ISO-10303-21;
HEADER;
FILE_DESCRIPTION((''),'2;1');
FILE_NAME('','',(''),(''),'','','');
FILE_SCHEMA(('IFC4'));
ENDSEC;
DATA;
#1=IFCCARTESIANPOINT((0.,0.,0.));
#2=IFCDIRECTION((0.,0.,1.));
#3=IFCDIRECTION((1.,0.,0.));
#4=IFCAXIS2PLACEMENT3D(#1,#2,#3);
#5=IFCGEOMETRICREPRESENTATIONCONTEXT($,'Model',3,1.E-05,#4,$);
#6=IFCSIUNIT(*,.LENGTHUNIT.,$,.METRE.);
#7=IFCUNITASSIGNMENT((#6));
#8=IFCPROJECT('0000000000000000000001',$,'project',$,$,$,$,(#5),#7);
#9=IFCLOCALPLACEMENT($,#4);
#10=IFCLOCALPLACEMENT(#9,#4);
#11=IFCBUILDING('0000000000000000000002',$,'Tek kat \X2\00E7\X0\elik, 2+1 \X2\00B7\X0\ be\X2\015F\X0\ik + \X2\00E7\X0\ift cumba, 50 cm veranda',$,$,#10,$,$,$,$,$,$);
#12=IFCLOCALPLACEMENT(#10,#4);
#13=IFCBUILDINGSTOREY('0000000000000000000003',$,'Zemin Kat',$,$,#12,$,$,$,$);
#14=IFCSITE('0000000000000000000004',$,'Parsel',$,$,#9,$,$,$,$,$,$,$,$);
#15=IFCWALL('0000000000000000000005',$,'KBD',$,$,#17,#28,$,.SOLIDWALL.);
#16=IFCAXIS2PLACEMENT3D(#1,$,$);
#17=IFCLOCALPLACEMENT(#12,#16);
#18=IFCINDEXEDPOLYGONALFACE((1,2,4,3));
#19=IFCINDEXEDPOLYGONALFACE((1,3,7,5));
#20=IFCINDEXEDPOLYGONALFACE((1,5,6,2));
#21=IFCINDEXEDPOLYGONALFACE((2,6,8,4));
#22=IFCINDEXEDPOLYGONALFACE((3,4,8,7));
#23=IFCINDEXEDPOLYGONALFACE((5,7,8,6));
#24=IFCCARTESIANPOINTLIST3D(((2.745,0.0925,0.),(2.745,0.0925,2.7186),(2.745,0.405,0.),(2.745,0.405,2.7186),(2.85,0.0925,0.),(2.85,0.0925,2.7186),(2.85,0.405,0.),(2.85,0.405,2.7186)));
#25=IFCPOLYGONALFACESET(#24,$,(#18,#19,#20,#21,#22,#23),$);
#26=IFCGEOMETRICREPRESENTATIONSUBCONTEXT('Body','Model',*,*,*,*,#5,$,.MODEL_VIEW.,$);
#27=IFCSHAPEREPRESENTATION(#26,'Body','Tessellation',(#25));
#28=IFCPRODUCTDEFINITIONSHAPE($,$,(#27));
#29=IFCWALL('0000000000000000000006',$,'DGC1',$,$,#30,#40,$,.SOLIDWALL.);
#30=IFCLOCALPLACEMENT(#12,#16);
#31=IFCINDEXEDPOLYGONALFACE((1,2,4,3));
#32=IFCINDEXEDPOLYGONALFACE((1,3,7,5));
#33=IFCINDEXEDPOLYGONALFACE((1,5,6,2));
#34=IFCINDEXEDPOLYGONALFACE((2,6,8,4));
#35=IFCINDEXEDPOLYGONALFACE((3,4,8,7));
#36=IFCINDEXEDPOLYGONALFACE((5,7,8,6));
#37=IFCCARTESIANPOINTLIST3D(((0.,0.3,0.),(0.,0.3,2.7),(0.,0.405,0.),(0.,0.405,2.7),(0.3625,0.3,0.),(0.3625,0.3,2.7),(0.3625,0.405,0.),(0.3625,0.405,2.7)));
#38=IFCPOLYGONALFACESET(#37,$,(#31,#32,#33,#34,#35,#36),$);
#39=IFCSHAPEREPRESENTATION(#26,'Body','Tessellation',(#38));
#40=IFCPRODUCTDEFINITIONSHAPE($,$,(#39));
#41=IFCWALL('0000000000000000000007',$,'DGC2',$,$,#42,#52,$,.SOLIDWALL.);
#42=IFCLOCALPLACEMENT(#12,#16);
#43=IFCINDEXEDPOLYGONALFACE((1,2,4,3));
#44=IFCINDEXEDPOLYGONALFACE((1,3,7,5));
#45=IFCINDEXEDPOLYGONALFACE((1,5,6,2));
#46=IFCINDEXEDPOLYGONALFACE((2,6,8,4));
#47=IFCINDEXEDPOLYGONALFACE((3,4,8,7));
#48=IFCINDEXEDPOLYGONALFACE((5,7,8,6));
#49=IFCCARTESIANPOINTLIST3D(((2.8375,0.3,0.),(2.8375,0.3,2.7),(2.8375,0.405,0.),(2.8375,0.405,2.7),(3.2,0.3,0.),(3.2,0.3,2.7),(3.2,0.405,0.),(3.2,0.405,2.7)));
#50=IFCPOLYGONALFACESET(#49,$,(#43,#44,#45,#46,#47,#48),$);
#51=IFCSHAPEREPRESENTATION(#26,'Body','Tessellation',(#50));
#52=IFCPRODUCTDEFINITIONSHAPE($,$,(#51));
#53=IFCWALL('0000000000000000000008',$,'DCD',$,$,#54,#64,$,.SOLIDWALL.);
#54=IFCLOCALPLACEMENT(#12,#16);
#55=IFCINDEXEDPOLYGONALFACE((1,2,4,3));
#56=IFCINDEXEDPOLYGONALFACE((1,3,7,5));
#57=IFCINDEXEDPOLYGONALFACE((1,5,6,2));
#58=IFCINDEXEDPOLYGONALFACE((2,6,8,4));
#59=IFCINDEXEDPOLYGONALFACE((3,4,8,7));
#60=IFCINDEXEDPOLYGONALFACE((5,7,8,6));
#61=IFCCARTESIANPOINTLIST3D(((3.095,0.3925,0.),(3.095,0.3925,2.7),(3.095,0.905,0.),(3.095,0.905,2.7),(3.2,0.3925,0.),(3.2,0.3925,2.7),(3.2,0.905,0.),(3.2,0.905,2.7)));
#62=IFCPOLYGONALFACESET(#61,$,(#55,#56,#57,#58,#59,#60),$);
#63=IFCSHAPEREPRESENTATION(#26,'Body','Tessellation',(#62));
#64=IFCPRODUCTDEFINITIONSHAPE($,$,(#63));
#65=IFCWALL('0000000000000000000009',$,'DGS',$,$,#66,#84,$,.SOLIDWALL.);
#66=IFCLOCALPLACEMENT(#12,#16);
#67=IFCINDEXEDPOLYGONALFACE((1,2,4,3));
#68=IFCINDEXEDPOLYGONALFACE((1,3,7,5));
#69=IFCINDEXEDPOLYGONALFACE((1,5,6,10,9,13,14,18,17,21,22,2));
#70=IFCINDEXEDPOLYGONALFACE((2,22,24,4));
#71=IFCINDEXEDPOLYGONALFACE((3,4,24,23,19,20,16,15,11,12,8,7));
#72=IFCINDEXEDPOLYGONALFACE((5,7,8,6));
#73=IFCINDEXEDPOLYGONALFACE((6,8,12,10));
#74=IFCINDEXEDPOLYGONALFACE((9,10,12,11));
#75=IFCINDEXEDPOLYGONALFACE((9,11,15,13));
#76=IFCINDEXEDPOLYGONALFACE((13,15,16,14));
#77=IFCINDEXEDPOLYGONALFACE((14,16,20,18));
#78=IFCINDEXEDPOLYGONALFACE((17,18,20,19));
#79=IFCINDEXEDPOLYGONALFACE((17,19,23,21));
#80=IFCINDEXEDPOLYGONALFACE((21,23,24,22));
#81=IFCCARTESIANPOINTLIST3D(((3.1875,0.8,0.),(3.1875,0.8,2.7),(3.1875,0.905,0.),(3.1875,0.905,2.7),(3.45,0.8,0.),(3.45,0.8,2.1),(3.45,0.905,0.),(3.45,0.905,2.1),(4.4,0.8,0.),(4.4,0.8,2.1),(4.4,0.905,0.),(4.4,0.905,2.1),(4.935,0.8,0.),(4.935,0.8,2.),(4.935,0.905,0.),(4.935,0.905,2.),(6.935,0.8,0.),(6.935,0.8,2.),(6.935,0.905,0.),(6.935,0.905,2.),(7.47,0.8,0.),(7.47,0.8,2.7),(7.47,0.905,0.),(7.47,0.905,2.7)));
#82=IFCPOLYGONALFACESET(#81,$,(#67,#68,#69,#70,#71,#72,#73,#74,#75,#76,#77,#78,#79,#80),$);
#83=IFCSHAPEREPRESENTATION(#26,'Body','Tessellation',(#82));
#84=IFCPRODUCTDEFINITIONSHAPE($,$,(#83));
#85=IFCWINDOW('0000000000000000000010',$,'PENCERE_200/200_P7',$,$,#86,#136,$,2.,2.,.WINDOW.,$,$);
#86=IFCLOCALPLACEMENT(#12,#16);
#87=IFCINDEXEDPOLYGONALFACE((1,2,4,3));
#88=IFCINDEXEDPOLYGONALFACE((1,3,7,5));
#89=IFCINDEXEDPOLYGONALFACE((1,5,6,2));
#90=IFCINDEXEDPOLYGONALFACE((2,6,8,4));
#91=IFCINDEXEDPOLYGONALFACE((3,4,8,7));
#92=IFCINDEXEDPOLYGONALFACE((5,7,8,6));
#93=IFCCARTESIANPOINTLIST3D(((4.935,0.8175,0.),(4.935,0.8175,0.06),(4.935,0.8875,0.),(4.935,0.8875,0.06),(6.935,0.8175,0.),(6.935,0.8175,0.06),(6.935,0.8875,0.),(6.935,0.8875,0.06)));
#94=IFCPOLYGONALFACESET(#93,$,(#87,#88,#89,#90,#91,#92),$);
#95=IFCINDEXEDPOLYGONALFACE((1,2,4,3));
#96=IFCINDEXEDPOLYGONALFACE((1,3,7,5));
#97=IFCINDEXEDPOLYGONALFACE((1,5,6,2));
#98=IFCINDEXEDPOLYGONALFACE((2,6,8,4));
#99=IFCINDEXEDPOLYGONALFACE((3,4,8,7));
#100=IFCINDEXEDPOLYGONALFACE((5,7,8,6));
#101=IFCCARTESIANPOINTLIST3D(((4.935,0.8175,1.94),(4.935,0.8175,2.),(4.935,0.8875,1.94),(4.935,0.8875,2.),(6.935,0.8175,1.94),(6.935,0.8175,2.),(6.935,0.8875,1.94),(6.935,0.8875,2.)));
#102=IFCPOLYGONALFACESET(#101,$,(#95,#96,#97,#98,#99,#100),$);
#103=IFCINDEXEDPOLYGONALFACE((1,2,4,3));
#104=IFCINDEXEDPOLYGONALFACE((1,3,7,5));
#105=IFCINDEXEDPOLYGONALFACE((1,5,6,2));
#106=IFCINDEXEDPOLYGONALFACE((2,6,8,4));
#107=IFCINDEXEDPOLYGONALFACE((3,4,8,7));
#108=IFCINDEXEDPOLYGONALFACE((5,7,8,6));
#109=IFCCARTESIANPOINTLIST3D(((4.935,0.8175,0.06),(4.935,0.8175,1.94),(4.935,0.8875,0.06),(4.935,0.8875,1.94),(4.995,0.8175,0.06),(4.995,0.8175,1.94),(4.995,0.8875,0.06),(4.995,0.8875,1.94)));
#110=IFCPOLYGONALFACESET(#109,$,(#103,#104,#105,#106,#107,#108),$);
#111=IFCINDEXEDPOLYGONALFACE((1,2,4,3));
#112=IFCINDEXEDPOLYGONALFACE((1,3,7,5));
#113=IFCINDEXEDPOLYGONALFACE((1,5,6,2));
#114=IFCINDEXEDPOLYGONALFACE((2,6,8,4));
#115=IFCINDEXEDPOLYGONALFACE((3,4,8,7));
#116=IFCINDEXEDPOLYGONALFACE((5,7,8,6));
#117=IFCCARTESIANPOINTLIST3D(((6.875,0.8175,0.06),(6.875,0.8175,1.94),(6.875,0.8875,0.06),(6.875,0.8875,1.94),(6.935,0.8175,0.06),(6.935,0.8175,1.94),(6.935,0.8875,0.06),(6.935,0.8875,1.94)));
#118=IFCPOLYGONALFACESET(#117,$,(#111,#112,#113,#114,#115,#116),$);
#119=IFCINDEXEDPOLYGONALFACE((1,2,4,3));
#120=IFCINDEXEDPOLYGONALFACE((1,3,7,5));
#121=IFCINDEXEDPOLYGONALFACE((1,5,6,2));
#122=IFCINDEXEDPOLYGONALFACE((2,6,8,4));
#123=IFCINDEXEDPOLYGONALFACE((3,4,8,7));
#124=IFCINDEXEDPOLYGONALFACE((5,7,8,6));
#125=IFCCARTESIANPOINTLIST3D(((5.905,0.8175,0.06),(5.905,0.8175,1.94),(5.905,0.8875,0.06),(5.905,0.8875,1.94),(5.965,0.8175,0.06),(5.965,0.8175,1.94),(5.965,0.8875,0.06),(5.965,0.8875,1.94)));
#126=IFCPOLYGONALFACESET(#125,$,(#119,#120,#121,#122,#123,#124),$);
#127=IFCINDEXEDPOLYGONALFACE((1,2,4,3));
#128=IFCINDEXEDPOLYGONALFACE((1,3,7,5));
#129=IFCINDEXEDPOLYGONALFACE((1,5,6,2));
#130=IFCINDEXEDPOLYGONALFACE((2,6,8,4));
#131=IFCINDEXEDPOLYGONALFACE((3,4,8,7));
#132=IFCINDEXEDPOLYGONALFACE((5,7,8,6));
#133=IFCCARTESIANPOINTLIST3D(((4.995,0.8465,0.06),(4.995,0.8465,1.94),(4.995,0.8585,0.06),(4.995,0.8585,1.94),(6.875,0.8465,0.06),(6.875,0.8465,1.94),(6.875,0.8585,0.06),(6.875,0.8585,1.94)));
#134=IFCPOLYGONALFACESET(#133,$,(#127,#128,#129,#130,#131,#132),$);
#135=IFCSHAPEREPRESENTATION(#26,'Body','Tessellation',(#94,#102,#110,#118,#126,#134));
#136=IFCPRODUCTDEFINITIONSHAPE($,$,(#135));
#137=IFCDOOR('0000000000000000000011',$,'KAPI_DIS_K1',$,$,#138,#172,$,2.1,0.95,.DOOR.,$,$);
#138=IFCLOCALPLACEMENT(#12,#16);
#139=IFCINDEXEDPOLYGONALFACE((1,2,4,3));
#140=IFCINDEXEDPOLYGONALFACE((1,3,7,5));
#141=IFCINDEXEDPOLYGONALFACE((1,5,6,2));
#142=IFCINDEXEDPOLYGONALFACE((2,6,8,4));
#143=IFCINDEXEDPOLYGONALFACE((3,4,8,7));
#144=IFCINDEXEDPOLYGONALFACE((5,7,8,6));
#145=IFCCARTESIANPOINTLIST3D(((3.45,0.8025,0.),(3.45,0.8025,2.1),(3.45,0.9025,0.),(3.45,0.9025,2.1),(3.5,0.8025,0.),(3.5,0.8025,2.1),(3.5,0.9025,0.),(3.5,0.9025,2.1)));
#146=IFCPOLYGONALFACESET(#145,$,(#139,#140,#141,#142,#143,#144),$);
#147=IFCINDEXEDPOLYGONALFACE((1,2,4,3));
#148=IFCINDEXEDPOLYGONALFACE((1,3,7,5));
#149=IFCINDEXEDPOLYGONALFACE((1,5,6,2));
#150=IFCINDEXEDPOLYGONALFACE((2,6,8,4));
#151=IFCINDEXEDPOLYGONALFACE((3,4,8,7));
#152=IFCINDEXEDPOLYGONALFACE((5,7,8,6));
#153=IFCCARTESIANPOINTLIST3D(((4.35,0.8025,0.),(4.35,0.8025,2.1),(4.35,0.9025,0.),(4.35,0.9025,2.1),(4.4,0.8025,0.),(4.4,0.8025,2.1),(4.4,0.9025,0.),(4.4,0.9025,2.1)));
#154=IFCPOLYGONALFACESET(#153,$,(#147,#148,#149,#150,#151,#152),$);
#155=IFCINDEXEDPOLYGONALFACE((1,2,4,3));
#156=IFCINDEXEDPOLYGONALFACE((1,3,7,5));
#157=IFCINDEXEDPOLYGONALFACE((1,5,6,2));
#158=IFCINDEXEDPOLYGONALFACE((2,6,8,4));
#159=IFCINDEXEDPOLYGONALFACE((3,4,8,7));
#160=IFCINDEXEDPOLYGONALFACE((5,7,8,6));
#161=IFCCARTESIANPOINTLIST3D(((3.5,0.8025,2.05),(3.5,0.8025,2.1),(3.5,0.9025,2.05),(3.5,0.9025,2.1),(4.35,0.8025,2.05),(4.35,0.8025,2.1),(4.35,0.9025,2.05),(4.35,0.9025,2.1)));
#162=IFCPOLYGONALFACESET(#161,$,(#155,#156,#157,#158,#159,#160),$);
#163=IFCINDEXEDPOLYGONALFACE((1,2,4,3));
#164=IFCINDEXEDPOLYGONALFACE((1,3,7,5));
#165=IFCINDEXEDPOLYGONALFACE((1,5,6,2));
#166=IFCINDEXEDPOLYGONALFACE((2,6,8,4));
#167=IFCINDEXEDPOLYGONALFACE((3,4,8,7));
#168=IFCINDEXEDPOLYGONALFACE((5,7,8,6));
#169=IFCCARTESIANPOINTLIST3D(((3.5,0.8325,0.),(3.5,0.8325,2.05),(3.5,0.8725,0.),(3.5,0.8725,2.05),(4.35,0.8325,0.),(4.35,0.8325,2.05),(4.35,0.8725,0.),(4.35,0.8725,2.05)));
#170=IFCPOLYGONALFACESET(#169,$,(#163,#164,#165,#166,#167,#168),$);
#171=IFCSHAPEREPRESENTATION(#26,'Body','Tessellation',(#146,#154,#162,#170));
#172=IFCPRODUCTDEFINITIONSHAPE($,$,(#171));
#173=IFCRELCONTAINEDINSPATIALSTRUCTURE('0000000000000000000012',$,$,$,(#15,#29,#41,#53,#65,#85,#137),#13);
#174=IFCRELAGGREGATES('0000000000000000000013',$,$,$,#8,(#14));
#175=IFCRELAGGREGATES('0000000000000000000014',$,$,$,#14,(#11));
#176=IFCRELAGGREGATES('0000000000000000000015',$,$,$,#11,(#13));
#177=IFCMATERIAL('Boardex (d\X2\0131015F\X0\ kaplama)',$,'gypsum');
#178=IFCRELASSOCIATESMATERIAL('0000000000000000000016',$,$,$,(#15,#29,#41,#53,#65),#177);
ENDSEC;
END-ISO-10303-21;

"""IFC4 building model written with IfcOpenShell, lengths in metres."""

from ifc_helpers import new_model, si_unit, frame, origin_with_axes, place, context, subcontext, project, spatial, line, indexed_curve, outline, extrude, material, element, fill, save


model = new_model("IFC4")

# Units and contexts
model_context = context("Model", 3, precision=1e-05, world=origin_with_axes())
body_context = subcontext(model_context, "Body", "Model", "MODEL_VIEW")
ifc_project = project(units=[si_unit("LENGTHUNIT", "METRE")], contexts=[model_context])

# Site, building, storey
site_placement = place(None, origin_with_axes())
site = spatial("IfcSite", under=ifc_project, at=site_placement, Name="Parsel")
building_placement = place(site_placement, origin_with_axes())
building = spatial("IfcBuilding", under=site, at=building_placement, Name="Tek kat çelik, 2+1 · beşik + çift cumba, 50 cm veranda")
storey_placement = place(building_placement, origin_with_axes())
storey = spatial("IfcBuildingStorey", under=building, at=storey_placement, Name="Zemin Kat")

# Shared definitions
ifc_material_1 = material(Name="Boardex (dış kaplama)", Category="gypsum")

# Walls
wall_1_placement = place(storey_placement, origin_with_axes())
element("IfcWall", 1, at=wall_1_placement, inside=storey, material=ifc_material_1, Name="KBD", PredefinedType="SOLIDWALL", context=body_context, shape_type="SweptSolid", body=[
    extrude(outline(indexed_curve([(0.0, 0.0), (0.105, 0.0), (0.105, 0.3125), (0.0, 0.3125)], segments=[line(1, 2, 3, 4, 1)])), frame((2.745, 0.0925, 0.0), z_axis=(0.0, 0.0, 1.0), x_axis=(1.0, 0.0, 0.0)), (0.0, 0.0, 1.0), 2.7186),
])
wall_2_placement = place(storey_placement, origin_with_axes())
element("IfcWall", 2, at=wall_2_placement, inside=storey, material=ifc_material_1, Name="DGC1", PredefinedType="SOLIDWALL", context=body_context, shape_type="SweptSolid", body=[
    extrude(outline(indexed_curve([(0.0, 0.0), (0.3625, 0.0), (0.3625, 0.105), (0.0, 0.105)], segments=[line(1, 2, 3, 4, 1)])), frame((0.0, 0.3, 0.0), z_axis=(0.0, 0.0, 1.0), x_axis=(1.0, 0.0, 0.0)), (0.0, 0.0, 1.0), 2.7),
])
wall_3_placement = place(storey_placement, origin_with_axes())
element("IfcWall", 3, at=wall_3_placement, inside=storey, material=ifc_material_1, Name="DGC2", PredefinedType="SOLIDWALL", context=body_context, shape_type="SweptSolid", body=[
    extrude(outline(indexed_curve([(0.0, 0.0), (0.3625, 0.0), (0.3625, 0.105), (0.0, 0.105)], segments=[line(1, 2, 3, 4, 1)])), frame((2.8375, 0.3, 0.0), z_axis=(0.0, 0.0, 1.0), x_axis=(1.0, 0.0, 0.0)), (0.0, 0.0, 1.0), 2.7),
])
wall_4_placement = place(storey_placement, origin_with_axes())
element("IfcWall", 4, at=wall_4_placement, inside=storey, material=ifc_material_1, Name="DCD", PredefinedType="SOLIDWALL", context=body_context, shape_type="SweptSolid", body=[
    extrude(outline(indexed_curve([(0.0, 0.0), (0.105, 0.0), (0.105, 0.5125), (0.0, 0.5125)], segments=[line(1, 2, 3, 4, 1)])), frame((3.095, 0.3925, 0.0), z_axis=(0.0, 0.0, 1.0), x_axis=(1.0, 0.0, 0.0)), (0.0, 0.0, 1.0), 2.7),
])

# Wall, openings, window, door
wall_5_placement = place(storey_placement, origin_with_axes())
wall_5 = element("IfcWall", 5, at=wall_5_placement, inside=storey, material=ifc_material_1, Name="DGS", PredefinedType="SOLIDWALL", context=body_context, shape_type="SweptSolid", body=[
    extrude(outline(indexed_curve([(0.0, 0.0), (4.2825, 0.0), (4.2825, 0.105), (0.0, 0.105)], segments=[line(1, 2, 3, 4, 1)])), frame((3.1875, 0.8, 0.0), z_axis=(0.0, 0.0, 1.0), x_axis=(1.0, 0.0, 0.0)), (0.0, 0.0, 1.0), 2.7),
])
opening_1_placement = place(wall_5_placement, origin_with_axes())
opening_1 = element("IfcOpeningElement", 6, at=opening_1_placement, cuts=wall_5, PredefinedType="OPENING", context=body_context, shape_type="SweptSolid", body=[
    extrude(outline(indexed_curve([(0.0, 0.0), (2.0, 0.0), (2.0, 0.145), (0.0, 0.145)], segments=[line(1, 2, 3, 4, 1)])), frame((4.935, 0.78, 0.0), z_axis=(0.0, 0.0, 1.0), x_axis=(1.0, 0.0, 0.0)), (0.0, 0.0, 1.0), 2.0),
])
opening_2_placement = place(wall_5_placement, origin_with_axes())
opening_2 = element("IfcOpeningElement", 7, at=opening_2_placement, cuts=wall_5, PredefinedType="OPENING", context=body_context, shape_type="SweptSolid", body=[
    extrude(outline(indexed_curve([(0.0, 0.0), (0.95, 0.0), (0.95, 0.145), (0.0, 0.145)], segments=[line(1, 2, 3, 4, 1)])), frame((3.45, 0.78, 0.0), z_axis=(0.0, 0.0, 1.0), x_axis=(1.0, 0.0, 0.0)), (0.0, 0.0, 1.0), 2.1),
])
window_1_placement = place(storey_placement, origin_with_axes())
window_1 = element("IfcWindow", 8, at=window_1_placement, inside=storey, Name="PENCERE_200/200_P7", OverallHeight=2.0, OverallWidth=2.0, PredefinedType="WINDOW", context=body_context, shape_type="SweptSolid", body=[
    extrude(outline(indexed_curve([(0.0, 0.0), (2.0, 0.0), (2.0, 0.07), (0.0, 0.07)], segments=[line(1, 2, 3, 4, 1)])), frame((4.935, 0.8175, 0.0), z_axis=(0.0, 0.0, 1.0), x_axis=(1.0, 0.0, 0.0)), (0.0, 0.0, 1.0), 0.06),
    extrude(outline(indexed_curve([(0.0, 0.0), (2.0, 0.0), (2.0, 0.07), (0.0, 0.07)], segments=[line(1, 2, 3, 4, 1)])), frame((4.935, 0.8175, 1.94), z_axis=(0.0, 0.0, 1.0), x_axis=(1.0, 0.0, 0.0)), (0.0, 0.0, 1.0), 0.06),
    extrude(outline(indexed_curve([(0.0, 0.0), (0.06, 0.0), (0.06, 0.07), (0.0, 0.07)], segments=[line(1, 2, 3, 4, 1)])), frame((4.935, 0.8175, 0.06), z_axis=(0.0, 0.0, 1.0), x_axis=(1.0, 0.0, 0.0)), (0.0, 0.0, 1.0), 1.88),
    extrude(outline(indexed_curve([(0.0, 0.0), (0.06, 0.0), (0.06, 0.07), (0.0, 0.07)], segments=[line(1, 2, 3, 4, 1)])), frame((6.875, 0.8175, 0.06), z_axis=(0.0, 0.0, 1.0), x_axis=(1.0, 0.0, 0.0)), (0.0, 0.0, 1.0), 1.88),
    extrude(outline(indexed_curve([(0.0, 0.0), (0.06, 0.0), (0.06, 0.07), (0.0, 0.07)], segments=[line(1, 2, 3, 4, 1)])), frame((5.905, 0.8175, 0.06), z_axis=(0.0, 0.0, 1.0), x_axis=(1.0, 0.0, 0.0)), (0.0, 0.0, 1.0), 1.88),
    extrude(outline(indexed_curve([(0.0, 0.0), (1.88, 0.0), (1.88, 0.012), (0.0, 0.012)], segments=[line(1, 2, 3, 4, 1)])), frame((4.995, 0.8465, 0.06), z_axis=(0.0, 0.0, 1.0), x_axis=(1.0, 0.0, 0.0)), (0.0, 0.0, 1.0), 1.88),
])
fill(opening_1, window_1)
door_1_placement = place(storey_placement, origin_with_axes())
door_1 = element("IfcDoor", 9, at=door_1_placement, inside=storey, Name="KAPI_DIS_K1", OverallHeight=2.1, OverallWidth=0.95, PredefinedType="DOOR", context=body_context, shape_type="SweptSolid", body=[
    extrude(outline(indexed_curve([(0.0, 0.0), (0.05, 0.0), (0.05, 0.1), (0.0, 0.1)], segments=[line(1, 2, 3, 4, 1)])), frame((3.45, 0.8025, 0.0), z_axis=(0.0, 0.0, 1.0), x_axis=(1.0, 0.0, 0.0)), (0.0, 0.0, 1.0), 2.1),
    extrude(outline(indexed_curve([(0.0, 0.0), (0.05, 0.0), (0.05, 0.1), (0.0, 0.1)], segments=[line(1, 2, 3, 4, 1)])), frame((4.35, 0.8025, 0.0), z_axis=(0.0, 0.0, 1.0), x_axis=(1.0, 0.0, 0.0)), (0.0, 0.0, 1.0), 2.1),
    extrude(outline(indexed_curve([(0.0, 0.0), (0.85, 0.0), (0.85, 0.1), (0.0, 0.1)], segments=[line(1, 2, 3, 4, 1)])), frame((3.5, 0.8025, 2.05), z_axis=(0.0, 0.0, 1.0), x_axis=(1.0, 0.0, 0.0)), (0.0, 0.0, 1.0), 0.05),
    extrude(outline(indexed_curve([(0.0, 0.0), (0.85, 0.0), (0.85, 0.04), (0.0, 0.04)], segments=[line(1, 2, 3, 4, 1)])), frame((3.5, 0.8325, 0.0), z_axis=(0.0, 0.0, 1.0), x_axis=(1.0, 0.0, 0.0)), (0.0, 0.0, 1.0), 2.05),
])
fill(opening_2, door_1)

save(model, "model.ifc")
